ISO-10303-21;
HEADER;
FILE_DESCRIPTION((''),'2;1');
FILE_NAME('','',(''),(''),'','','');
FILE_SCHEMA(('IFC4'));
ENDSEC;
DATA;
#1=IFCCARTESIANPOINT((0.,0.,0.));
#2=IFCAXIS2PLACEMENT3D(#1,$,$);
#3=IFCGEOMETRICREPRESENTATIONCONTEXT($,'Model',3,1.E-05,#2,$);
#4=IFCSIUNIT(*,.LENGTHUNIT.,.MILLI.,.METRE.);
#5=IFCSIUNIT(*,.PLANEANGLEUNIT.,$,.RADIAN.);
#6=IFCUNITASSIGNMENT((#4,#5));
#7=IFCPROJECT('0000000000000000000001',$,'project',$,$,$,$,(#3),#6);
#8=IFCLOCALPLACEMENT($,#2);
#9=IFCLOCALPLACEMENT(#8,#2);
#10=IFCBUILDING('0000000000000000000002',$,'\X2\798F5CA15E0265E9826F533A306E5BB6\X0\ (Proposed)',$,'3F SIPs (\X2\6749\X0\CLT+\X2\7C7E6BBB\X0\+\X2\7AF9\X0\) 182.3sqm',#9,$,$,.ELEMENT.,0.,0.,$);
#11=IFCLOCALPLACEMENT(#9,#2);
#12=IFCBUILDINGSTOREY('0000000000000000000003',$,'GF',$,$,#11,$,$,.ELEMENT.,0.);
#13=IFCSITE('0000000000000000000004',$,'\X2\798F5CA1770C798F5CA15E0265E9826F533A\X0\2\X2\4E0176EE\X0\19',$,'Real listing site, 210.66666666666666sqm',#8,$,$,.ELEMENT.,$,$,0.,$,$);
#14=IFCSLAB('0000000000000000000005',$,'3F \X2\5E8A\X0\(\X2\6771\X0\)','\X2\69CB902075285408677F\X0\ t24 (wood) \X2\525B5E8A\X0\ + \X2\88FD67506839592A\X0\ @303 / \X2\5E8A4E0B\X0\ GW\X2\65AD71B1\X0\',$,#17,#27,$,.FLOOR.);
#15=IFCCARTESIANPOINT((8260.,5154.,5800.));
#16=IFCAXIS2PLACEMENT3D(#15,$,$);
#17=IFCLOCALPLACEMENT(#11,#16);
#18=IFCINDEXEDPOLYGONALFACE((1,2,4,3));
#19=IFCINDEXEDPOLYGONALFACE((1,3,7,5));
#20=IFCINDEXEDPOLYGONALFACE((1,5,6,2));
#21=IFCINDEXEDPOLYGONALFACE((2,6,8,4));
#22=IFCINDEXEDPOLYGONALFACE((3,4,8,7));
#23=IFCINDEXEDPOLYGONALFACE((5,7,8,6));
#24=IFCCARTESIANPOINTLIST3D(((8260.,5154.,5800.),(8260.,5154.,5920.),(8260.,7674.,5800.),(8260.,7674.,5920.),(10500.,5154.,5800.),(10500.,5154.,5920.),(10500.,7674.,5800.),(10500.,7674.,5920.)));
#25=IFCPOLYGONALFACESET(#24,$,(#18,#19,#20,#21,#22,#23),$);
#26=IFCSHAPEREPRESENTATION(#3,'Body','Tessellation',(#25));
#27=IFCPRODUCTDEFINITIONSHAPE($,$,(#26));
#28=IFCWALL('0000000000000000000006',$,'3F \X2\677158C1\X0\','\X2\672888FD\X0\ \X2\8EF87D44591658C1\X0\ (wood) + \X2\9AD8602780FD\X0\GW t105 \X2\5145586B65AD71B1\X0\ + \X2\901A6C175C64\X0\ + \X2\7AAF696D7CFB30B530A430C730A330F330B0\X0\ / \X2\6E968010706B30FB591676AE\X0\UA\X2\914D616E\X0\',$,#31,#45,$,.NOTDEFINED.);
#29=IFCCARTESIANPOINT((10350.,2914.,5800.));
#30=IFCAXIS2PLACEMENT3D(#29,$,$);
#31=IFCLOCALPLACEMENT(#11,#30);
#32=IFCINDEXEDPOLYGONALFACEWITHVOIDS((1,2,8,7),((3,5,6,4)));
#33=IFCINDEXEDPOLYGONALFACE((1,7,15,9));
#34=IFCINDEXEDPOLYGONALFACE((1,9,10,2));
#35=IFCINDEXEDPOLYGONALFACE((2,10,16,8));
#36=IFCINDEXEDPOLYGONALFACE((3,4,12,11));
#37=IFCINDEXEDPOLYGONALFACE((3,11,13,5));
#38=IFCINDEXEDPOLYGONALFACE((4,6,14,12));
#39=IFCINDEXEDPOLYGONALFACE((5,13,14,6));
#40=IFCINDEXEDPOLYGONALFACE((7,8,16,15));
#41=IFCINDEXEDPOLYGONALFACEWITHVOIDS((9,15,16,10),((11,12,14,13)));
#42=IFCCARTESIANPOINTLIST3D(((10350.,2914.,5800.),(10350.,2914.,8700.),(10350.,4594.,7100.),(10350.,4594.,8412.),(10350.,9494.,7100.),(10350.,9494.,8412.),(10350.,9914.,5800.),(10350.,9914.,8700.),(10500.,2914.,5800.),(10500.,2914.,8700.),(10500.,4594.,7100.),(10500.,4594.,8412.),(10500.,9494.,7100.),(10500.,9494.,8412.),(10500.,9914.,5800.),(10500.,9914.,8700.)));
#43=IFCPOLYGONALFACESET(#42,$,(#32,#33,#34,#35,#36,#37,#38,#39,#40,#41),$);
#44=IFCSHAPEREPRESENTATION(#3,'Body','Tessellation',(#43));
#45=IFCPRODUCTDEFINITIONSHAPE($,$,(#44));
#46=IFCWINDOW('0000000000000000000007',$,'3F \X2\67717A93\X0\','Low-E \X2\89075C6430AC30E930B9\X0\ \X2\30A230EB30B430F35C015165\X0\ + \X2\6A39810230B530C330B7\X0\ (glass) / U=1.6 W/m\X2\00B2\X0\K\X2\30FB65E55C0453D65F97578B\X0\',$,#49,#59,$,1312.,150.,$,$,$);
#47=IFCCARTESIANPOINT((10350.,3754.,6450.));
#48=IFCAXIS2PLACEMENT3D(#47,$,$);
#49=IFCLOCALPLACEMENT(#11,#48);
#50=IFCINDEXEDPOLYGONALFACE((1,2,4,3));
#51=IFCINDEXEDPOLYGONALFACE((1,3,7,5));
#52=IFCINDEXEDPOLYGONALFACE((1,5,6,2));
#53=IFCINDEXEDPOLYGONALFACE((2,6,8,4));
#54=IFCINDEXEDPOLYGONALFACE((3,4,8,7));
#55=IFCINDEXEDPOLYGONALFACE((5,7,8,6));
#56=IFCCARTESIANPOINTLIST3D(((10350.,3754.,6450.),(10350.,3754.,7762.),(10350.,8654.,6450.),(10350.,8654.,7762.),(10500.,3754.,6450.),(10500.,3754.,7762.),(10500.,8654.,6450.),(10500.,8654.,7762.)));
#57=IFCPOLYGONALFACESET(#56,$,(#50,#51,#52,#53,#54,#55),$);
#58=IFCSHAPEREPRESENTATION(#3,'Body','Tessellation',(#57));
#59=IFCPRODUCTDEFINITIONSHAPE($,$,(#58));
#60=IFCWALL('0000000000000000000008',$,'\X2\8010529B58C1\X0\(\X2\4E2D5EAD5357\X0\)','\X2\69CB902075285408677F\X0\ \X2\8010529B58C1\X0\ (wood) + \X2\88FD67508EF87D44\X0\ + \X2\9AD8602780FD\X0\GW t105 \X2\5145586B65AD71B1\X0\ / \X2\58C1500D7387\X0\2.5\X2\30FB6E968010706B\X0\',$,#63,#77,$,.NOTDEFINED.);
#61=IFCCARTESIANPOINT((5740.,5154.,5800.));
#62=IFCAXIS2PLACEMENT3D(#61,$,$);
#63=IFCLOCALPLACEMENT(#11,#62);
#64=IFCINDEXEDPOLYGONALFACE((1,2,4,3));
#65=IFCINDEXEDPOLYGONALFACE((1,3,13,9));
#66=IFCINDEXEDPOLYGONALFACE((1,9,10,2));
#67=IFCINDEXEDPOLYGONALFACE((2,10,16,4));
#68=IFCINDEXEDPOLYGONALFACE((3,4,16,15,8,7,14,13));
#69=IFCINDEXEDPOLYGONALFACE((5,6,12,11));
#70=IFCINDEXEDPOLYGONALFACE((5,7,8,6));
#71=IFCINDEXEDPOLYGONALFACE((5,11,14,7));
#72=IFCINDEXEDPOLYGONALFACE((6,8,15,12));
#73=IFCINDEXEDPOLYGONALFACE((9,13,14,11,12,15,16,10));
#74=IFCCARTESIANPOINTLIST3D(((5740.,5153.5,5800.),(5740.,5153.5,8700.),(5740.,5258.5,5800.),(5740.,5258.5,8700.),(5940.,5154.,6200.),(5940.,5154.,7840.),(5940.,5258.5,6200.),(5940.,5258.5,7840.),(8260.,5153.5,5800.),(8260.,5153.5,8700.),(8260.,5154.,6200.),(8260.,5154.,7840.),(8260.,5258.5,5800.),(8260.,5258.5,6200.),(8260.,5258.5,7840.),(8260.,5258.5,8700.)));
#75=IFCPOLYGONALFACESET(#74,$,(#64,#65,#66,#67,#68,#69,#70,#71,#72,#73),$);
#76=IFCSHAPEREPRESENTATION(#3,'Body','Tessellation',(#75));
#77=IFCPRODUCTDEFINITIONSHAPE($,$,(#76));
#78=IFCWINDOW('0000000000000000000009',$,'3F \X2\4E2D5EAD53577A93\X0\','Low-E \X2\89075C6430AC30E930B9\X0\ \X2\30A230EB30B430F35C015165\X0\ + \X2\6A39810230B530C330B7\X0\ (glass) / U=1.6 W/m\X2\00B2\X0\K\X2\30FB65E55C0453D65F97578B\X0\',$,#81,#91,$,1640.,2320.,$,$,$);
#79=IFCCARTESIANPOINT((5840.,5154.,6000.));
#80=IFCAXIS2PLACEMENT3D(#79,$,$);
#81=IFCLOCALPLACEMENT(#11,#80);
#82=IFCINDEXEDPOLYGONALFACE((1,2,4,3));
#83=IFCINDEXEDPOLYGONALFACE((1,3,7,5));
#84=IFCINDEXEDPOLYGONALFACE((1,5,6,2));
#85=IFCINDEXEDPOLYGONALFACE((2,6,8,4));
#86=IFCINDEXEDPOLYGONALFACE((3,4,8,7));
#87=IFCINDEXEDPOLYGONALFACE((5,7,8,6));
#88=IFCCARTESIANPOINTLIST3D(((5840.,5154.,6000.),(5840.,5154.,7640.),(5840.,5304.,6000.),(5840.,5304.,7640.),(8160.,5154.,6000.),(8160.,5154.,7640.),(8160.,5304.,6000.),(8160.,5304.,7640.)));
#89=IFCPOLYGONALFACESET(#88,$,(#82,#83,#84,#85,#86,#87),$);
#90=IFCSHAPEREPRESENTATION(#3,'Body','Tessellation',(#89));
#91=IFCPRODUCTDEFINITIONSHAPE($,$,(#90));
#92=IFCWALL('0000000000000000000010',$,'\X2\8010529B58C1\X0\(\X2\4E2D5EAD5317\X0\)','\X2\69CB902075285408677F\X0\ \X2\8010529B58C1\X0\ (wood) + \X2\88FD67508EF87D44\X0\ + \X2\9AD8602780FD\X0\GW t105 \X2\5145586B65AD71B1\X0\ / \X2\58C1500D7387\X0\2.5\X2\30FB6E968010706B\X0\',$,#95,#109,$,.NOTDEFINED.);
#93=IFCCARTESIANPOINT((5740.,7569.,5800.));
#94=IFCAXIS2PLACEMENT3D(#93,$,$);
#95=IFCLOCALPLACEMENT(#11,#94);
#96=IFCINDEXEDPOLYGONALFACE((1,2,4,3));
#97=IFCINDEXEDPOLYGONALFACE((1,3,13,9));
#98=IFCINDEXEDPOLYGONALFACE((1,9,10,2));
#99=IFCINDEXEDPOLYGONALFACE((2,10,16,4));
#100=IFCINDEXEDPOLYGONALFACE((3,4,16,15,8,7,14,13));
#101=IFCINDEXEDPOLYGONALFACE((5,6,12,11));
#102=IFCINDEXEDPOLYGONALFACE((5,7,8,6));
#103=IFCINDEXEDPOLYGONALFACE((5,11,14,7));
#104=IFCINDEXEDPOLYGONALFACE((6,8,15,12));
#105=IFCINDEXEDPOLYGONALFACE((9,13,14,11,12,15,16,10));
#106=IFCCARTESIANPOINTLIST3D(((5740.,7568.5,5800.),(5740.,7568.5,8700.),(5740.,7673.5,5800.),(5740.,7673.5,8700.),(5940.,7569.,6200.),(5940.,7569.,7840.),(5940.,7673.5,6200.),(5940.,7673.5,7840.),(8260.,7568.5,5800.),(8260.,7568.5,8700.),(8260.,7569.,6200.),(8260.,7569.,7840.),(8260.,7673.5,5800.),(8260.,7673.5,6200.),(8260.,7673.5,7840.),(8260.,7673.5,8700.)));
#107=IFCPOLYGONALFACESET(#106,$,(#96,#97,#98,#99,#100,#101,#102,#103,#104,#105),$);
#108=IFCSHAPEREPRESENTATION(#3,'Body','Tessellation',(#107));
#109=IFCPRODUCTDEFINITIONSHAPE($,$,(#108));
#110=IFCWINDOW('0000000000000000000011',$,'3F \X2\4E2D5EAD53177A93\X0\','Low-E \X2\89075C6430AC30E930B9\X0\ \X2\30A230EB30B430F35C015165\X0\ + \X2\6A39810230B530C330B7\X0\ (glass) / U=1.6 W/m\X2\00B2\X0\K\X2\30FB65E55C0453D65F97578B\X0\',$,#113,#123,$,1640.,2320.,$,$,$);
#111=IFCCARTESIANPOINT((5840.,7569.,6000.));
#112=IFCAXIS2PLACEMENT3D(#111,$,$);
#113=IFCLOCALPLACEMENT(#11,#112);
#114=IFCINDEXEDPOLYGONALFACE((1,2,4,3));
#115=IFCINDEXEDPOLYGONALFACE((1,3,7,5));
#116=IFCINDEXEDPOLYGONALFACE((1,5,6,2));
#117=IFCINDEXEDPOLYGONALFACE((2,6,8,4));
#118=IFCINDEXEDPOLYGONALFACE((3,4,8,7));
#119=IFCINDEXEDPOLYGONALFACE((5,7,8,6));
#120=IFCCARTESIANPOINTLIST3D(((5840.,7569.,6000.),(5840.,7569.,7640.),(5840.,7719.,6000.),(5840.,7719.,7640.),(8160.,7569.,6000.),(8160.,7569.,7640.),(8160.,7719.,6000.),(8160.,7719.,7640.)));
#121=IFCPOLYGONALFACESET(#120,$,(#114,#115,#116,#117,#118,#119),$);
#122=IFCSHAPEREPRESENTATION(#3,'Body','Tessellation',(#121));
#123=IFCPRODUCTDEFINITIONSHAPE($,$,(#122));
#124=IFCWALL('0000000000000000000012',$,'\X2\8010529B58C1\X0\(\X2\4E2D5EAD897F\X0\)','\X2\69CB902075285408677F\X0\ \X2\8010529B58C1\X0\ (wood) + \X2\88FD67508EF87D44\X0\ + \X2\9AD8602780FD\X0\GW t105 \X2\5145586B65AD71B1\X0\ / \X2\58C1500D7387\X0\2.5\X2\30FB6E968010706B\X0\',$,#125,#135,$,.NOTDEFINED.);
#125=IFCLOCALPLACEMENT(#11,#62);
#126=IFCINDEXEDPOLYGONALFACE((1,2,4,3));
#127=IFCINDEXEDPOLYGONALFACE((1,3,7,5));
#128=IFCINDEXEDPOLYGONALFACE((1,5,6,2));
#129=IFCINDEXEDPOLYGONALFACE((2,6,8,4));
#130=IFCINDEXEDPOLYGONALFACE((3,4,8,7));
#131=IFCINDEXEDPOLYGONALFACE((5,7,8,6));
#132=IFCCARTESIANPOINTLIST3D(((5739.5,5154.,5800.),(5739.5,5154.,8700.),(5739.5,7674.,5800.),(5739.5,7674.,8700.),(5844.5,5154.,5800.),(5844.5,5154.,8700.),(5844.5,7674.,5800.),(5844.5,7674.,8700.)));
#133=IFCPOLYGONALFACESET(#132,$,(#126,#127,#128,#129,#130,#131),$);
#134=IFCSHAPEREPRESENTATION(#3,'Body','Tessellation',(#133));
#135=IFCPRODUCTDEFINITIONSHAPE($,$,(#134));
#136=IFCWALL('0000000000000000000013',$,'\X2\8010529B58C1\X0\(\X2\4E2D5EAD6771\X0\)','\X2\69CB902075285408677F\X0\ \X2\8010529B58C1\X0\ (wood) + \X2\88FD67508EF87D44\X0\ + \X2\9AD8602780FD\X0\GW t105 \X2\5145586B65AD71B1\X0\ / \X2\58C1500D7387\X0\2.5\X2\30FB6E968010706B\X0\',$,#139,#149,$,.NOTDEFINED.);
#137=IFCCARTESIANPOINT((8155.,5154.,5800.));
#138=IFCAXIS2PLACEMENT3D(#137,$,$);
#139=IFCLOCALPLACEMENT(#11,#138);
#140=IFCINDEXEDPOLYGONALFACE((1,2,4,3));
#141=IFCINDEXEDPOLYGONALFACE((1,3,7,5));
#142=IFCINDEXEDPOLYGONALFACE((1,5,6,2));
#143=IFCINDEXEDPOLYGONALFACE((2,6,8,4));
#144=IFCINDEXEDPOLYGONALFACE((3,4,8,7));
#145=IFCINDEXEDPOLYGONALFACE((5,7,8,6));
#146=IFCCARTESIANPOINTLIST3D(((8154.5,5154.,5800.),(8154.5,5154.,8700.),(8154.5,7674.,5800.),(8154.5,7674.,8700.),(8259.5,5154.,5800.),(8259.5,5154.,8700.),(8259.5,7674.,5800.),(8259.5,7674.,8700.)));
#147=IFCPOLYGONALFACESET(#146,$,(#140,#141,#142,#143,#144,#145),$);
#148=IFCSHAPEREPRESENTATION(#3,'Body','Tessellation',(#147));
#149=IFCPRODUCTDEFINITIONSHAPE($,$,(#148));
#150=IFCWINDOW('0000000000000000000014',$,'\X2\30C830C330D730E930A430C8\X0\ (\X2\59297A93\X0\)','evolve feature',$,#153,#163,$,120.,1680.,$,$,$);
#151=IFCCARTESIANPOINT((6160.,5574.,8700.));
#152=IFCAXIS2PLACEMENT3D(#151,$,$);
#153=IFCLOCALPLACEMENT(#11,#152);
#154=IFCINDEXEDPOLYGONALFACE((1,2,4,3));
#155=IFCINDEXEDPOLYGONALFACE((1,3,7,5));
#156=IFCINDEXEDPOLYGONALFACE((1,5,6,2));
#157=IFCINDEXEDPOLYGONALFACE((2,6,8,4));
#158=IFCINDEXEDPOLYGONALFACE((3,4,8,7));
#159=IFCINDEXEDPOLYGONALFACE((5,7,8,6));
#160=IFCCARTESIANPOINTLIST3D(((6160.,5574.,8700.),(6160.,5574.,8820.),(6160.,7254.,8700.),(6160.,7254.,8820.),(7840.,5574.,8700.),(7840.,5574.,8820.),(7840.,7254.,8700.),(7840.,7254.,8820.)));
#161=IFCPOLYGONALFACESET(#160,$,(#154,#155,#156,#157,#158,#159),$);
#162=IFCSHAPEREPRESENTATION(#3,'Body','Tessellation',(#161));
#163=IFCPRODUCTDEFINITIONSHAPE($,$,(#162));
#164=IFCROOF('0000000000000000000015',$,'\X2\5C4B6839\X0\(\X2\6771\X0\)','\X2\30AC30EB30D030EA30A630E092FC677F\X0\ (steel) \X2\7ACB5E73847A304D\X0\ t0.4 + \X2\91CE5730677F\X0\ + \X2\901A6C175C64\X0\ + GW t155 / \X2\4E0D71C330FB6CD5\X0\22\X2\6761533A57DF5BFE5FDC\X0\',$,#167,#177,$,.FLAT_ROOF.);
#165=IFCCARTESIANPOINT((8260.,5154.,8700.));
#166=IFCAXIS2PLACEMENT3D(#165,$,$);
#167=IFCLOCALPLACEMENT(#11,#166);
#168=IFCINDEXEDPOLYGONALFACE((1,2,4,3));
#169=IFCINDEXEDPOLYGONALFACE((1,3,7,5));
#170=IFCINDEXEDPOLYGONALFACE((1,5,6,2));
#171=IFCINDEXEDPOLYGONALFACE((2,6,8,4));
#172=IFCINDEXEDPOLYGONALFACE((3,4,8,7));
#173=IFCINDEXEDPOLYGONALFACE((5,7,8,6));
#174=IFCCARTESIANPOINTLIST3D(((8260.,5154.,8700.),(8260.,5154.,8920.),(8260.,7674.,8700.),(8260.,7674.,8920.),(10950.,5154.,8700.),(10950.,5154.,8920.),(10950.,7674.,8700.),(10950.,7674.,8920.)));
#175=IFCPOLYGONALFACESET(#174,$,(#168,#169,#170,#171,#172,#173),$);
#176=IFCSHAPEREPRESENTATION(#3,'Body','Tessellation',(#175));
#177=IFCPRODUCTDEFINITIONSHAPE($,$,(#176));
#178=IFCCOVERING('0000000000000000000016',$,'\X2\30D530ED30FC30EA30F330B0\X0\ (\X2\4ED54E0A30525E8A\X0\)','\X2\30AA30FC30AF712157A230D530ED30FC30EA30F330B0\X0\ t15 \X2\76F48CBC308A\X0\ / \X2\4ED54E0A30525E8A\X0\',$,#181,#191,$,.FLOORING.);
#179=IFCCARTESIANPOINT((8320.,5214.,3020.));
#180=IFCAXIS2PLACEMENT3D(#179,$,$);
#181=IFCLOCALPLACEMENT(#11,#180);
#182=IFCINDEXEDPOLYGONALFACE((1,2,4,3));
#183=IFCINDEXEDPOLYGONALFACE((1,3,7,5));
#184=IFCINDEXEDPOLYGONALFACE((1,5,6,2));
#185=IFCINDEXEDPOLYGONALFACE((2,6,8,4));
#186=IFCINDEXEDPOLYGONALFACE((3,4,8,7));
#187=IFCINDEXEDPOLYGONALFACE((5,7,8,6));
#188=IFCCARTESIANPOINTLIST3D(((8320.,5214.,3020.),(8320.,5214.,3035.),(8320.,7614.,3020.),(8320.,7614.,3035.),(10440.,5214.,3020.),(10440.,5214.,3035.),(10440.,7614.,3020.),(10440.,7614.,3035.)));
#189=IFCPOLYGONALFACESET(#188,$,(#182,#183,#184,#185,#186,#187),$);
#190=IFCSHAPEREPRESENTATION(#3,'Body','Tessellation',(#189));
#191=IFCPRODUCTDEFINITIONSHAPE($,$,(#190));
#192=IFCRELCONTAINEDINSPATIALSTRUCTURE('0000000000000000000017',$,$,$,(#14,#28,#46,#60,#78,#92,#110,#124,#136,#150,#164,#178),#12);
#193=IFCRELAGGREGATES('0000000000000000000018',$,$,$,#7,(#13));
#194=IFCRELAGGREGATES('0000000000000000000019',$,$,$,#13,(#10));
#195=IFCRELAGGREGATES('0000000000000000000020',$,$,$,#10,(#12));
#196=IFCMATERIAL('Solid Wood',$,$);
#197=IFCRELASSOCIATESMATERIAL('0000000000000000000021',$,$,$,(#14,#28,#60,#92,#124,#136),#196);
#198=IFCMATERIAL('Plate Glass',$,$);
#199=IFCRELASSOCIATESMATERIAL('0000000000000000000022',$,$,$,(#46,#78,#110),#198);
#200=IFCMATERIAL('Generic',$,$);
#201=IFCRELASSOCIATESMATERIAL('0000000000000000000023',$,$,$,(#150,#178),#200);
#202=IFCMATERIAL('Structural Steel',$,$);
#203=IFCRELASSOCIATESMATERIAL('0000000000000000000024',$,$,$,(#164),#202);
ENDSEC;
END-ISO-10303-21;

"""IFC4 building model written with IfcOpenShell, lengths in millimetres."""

from ifc_helpers import new_model, si_unit, frame, frame_2d, origin, place, context, project, spatial, rectangle, extrude, material, element, fill, save


model = new_model("IFC4")

# Units and contexts
model_context = context("Model", 3, precision=1e-05, world=origin())
ifc_project = project(units=[si_unit("LENGTHUNIT", "METRE", prefix="MILLI"), si_unit("PLANEANGLEUNIT", "RADIAN")], contexts=[model_context])

# Site, building, storey
site_placement = place(None, origin())
site = spatial("IfcSite", under=ifc_project, at=site_placement, Name="福岡県福岡市早良区2丁目19", ObjectType="Real listing site, 210.66666666666666sqm", CompositionType="ELEMENT", RefElevation=0.0)
building_placement = place(site_placement, origin())
building = spatial("IfcBuilding", under=site, at=building_placement, Name="福岡市早良区の家 (Proposed)", ObjectType="3F SIPs (杉CLT+籾殻+竹) 182.3sqm", CompositionType="ELEMENT", ElevationOfRefHeight=0.0, ElevationOfTerrain=0.0)
storey_placement = place(building_placement, origin())
storey = spatial("IfcBuildingStorey", under=building, at=storey_placement, Name="GF", CompositionType="ELEMENT", Elevation=0.0)

# Slab
ifc_material_1 = material(Name="Solid Wood")
slab_placement = place(storey_placement, frame((8260.0, 5154.0, 5800.0)))
element("IfcSlab", 1, at=slab_placement, inside=storey, material=ifc_material_1, Name="3F 床(東)", Description="構造用合板 t24 (wood) 剛床 + 製材根太 @303 / 床下 GW断熱", PredefinedType="FLOOR", context=model_context, shape_type="SweptSolid", body=[
    extrude(rectangle(XDim=2240.0, YDim=2520.0, at=frame_2d((1120.0, 1260.0))), frame((8260.0, 5154.0, 5800.0)), (0.0, 0.0, 1.0), 120.0),
])

# Walls, openings, windows
wall_1_placement = place(storey_placement, frame((10350.0, 2914.0, 5800.0)))
wall_1 = element("IfcWall", 2, at=wall_1_placement, inside=storey, material=ifc_material_1, Name="3F 東壁", Description="木製 軸組外壁 (wood) + 高性能GW t105 充填断熱 + 通気層 + 窯業系サイディング / 準耐火・外皮UA配慮", PredefinedType="NOTDEFINED", context=model_context, shape_type="SweptSolid", body=[
    extrude(rectangle(XDim=150.0, YDim=7000.0, at=frame_2d((75.0, 3500.0))), frame((10350.0, 2914.0, 5800.0)), (0.0, 0.0, 1.0), 2900.0),
])
opening_1_placement = place(storey_placement, frame((10350.0, 3754.0, 6450.0)))
opening_1 = element("IfcOpeningElement", 3, at=opening_1_placement, cuts=wall_1, PredefinedType="NOTDEFINED", context=model_context, shape_type="SweptSolid", body=[
    extrude(rectangle(XDim=150.0, YDim=4900.0, at=frame_2d((75.0, 2450.0))), frame((10350.0, 3754.0, 6450.0)), (0.0, 0.0, 1.0), 1312.0),
])
ifc_material_2 = material(Name="Plate Glass")
window_1_placement = place(storey_placement, frame((10350.0, 3754.0, 6450.0)))
window_1 = element("IfcWindow", 4, at=window_1_placement, inside=storey, material=ifc_material_2, Name="3F 東窓", Description="Low-E 複層ガラス アルゴン封入 + 樹脂サッシ (glass) / U=1.6 W/m²K・日射取得型", OverallHeight=1312.0, OverallWidth=150.0, context=model_context, shape_type="SweptSolid", body=[
    extrude(rectangle(XDim=150.0, YDim=4900.0, at=frame_2d((75.0, 2450.0))), frame((10350.0, 3754.0, 6450.0)), (0.0, 0.0, 1.0), 1312.0),
])
fill(opening_1, window_1)
wall_2_placement = place(storey_placement, frame((5740.0, 5154.0, 5800.0)))
wall_2 = element("IfcWall", 5, at=wall_2_placement, inside=storey, material=ifc_material_1, Name="耐力壁(中庭南)", Description="構造用合板 耐力壁 (wood) + 製材軸組 + 高性能GW t105 充填断熱 / 壁倍率2.5・準耐火", PredefinedType="NOTDEFINED", context=model_context, shape_type="SweptSolid", body=[
    extrude(rectangle(XDim=2520.0, YDim=105.0, at=frame_2d((1260.0, 52.0))), frame((5740.0, 5154.0, 5800.0)), (0.0, 0.0, 1.0), 2900.0),
])
opening_2_placement = place(storey_placement, frame((5840.0, 5154.0, 6000.0)))
opening_2 = element("IfcOpeningElement", 6, at=opening_2_placement, cuts=wall_2, PredefinedType="NOTDEFINED", context=model_context, shape_type="SweptSolid", body=[
    extrude(rectangle(XDim=2320.0, YDim=150.0, at=frame_2d((1160.0, 75.0))), frame((5840.0, 5154.0, 6000.0)), (0.0, 0.0, 1.0), 1640.0),
])
window_2_placement = place(storey_placement, frame((5840.0, 5154.0, 6000.0)))
window_2 = element("IfcWindow", 7, at=window_2_placement, inside=storey, material=ifc_material_2, Name="3F 中庭南窓", Description="Low-E 複層ガラス アルゴン封入 + 樹脂サッシ (glass) / U=1.6 W/m²K・日射取得型", OverallHeight=1640.0, OverallWidth=2320.0, context=model_context, shape_type="SweptSolid", body=[
    extrude(rectangle(XDim=2320.0, YDim=150.0, at=frame_2d((1160.0, 75.0))), frame((5840.0, 5154.0, 6000.0)), (0.0, 0.0, 1.0), 1640.0),
])
fill(opening_2, window_2)
wall_3_placement = place(storey_placement, frame((5740.0, 7569.0, 5800.0)))
wall_3 = element("IfcWall", 8, at=wall_3_placement, inside=storey, material=ifc_material_1, Name="耐力壁(中庭北)", Description="構造用合板 耐力壁 (wood) + 製材軸組 + 高性能GW t105 充填断熱 / 壁倍率2.5・準耐火", PredefinedType="NOTDEFINED", context=model_context, shape_type="SweptSolid", body=[
    extrude(rectangle(XDim=2520.0, YDim=105.0, at=frame_2d((1260.0, 52.0))), frame((5740.0, 7569.0, 5800.0)), (0.0, 0.0, 1.0), 2900.0),
])
opening_3_placement = place(storey_placement, frame((5840.0, 7569.0, 6000.0)))
opening_3 = element("IfcOpeningElement", 9, at=opening_3_placement, cuts=wall_3, PredefinedType="NOTDEFINED", context=model_context, shape_type="SweptSolid", body=[
    extrude(rectangle(XDim=2320.0, YDim=150.0, at=frame_2d((1160.0, 75.0))), frame((5840.0, 7569.0, 6000.0)), (0.0, 0.0, 1.0), 1640.0),
])
window_3_placement = place(storey_placement, frame((5840.0, 7569.0, 6000.0)))
window_3 = element("IfcWindow", 10, at=window_3_placement, inside=storey, material=ifc_material_2, Name="3F 中庭北窓", Description="Low-E 複層ガラス アルゴン封入 + 樹脂サッシ (glass) / U=1.6 W/m²K・日射取得型", OverallHeight=1640.0, OverallWidth=2320.0, context=model_context, shape_type="SweptSolid", body=[
    extrude(rectangle(XDim=2320.0, YDim=150.0, at=frame_2d((1160.0, 75.0))), frame((5840.0, 7569.0, 6000.0)), (0.0, 0.0, 1.0), 1640.0),
])
fill(opening_3, window_3)

# Walls
wall_4_placement = place(storey_placement, frame((5740.0, 5154.0, 5800.0)))
element("IfcWall", 11, at=wall_4_placement, inside=storey, material=ifc_material_1, Name="耐力壁(中庭西)", Description="構造用合板 耐力壁 (wood) + 製材軸組 + 高性能GW t105 充填断熱 / 壁倍率2.5・準耐火", PredefinedType="NOTDEFINED", context=model_context, shape_type="SweptSolid", body=[
    extrude(rectangle(XDim=105.0, YDim=2520.0, at=frame_2d((52.0, 1260.0))), frame((5740.0, 5154.0, 5800.0)), (0.0, 0.0, 1.0), 2900.0),
])
wall_5_placement = place(storey_placement, frame((8155.0, 5154.0, 5800.0)))
element("IfcWall", 12, at=wall_5_placement, inside=storey, material=ifc_material_1, Name="耐力壁(中庭東)", Description="構造用合板 耐力壁 (wood) + 製材軸組 + 高性能GW t105 充填断熱 / 壁倍率2.5・準耐火", PredefinedType="NOTDEFINED", context=model_context, shape_type="SweptSolid", body=[
    extrude(rectangle(XDim=105.0, YDim=2520.0, at=frame_2d((52.0, 1260.0))), frame((8155.0, 5154.0, 5800.0)), (0.0, 0.0, 1.0), 2900.0),
])

# Window
ifc_material_3 = material(Name="Generic")
window_4_placement = place(storey_placement, frame((6160.0, 5574.0, 8700.0)))
element("IfcWindow", 13, at=window_4_placement, inside=storey, material=ifc_material_3, Name="トップライト (天窓)", Description="evolve feature", OverallHeight=120.0, OverallWidth=1680.0, context=model_context, shape_type="SweptSolid", body=[
    extrude(rectangle(XDim=1680.0, YDim=1680.0, at=frame_2d((840.0, 840.0))), frame((6160.0, 5574.0, 8700.0)), (0.0, 0.0, 1.0), 120.0),
])

# Roof
ifc_material_4 = material(Name="Structural Steel")
for number, where, name in (
    (14, (8260.0, 5154.0, 8700.0), "屋根(東)"),
):
    element("IfcRoof", number, at=place(storey_placement, frame(where)), inside=storey, material=ifc_material_4, Name=name, Description="ガルバリウム鋼板 (steel) 立平葺き t0.4 + 野地板 + 通気層 + GW t155 / 不燃・法22条区域対応", PredefinedType="FLAT_ROOF", context=model_context, shape_type="SweptSolid", body=[
        extrude(rectangle(XDim=2690.0, YDim=2520.0, at=frame_2d((1345.0, 1260.0))), frame((8260.0, 5154.0, 8700.0)), (0.0, 0.0, 1.0), 220.0),
    ])

# Covering
covering_1_placement = place(storey_placement, frame((8320.0, 5214.0, 3020.0)))
element("IfcCovering", 15, at=covering_1_placement, inside=storey, material=ifc_material_3, Name="フローリング (仕上げ床)", Description="オーク無垢フローリング t15 直貼り / 仕上げ床", PredefinedType="FLOORING", context=model_context, shape_type="SweptSolid", body=[
    extrude(rectangle(XDim=2120.0, YDim=2400.0, at=frame_2d((1060.0, 1200.0))), frame((8320.0, 5214.0, 3020.0)), (0.0, 0.0, 1.0), 15.0),
])

save(model, "model.ifc")
